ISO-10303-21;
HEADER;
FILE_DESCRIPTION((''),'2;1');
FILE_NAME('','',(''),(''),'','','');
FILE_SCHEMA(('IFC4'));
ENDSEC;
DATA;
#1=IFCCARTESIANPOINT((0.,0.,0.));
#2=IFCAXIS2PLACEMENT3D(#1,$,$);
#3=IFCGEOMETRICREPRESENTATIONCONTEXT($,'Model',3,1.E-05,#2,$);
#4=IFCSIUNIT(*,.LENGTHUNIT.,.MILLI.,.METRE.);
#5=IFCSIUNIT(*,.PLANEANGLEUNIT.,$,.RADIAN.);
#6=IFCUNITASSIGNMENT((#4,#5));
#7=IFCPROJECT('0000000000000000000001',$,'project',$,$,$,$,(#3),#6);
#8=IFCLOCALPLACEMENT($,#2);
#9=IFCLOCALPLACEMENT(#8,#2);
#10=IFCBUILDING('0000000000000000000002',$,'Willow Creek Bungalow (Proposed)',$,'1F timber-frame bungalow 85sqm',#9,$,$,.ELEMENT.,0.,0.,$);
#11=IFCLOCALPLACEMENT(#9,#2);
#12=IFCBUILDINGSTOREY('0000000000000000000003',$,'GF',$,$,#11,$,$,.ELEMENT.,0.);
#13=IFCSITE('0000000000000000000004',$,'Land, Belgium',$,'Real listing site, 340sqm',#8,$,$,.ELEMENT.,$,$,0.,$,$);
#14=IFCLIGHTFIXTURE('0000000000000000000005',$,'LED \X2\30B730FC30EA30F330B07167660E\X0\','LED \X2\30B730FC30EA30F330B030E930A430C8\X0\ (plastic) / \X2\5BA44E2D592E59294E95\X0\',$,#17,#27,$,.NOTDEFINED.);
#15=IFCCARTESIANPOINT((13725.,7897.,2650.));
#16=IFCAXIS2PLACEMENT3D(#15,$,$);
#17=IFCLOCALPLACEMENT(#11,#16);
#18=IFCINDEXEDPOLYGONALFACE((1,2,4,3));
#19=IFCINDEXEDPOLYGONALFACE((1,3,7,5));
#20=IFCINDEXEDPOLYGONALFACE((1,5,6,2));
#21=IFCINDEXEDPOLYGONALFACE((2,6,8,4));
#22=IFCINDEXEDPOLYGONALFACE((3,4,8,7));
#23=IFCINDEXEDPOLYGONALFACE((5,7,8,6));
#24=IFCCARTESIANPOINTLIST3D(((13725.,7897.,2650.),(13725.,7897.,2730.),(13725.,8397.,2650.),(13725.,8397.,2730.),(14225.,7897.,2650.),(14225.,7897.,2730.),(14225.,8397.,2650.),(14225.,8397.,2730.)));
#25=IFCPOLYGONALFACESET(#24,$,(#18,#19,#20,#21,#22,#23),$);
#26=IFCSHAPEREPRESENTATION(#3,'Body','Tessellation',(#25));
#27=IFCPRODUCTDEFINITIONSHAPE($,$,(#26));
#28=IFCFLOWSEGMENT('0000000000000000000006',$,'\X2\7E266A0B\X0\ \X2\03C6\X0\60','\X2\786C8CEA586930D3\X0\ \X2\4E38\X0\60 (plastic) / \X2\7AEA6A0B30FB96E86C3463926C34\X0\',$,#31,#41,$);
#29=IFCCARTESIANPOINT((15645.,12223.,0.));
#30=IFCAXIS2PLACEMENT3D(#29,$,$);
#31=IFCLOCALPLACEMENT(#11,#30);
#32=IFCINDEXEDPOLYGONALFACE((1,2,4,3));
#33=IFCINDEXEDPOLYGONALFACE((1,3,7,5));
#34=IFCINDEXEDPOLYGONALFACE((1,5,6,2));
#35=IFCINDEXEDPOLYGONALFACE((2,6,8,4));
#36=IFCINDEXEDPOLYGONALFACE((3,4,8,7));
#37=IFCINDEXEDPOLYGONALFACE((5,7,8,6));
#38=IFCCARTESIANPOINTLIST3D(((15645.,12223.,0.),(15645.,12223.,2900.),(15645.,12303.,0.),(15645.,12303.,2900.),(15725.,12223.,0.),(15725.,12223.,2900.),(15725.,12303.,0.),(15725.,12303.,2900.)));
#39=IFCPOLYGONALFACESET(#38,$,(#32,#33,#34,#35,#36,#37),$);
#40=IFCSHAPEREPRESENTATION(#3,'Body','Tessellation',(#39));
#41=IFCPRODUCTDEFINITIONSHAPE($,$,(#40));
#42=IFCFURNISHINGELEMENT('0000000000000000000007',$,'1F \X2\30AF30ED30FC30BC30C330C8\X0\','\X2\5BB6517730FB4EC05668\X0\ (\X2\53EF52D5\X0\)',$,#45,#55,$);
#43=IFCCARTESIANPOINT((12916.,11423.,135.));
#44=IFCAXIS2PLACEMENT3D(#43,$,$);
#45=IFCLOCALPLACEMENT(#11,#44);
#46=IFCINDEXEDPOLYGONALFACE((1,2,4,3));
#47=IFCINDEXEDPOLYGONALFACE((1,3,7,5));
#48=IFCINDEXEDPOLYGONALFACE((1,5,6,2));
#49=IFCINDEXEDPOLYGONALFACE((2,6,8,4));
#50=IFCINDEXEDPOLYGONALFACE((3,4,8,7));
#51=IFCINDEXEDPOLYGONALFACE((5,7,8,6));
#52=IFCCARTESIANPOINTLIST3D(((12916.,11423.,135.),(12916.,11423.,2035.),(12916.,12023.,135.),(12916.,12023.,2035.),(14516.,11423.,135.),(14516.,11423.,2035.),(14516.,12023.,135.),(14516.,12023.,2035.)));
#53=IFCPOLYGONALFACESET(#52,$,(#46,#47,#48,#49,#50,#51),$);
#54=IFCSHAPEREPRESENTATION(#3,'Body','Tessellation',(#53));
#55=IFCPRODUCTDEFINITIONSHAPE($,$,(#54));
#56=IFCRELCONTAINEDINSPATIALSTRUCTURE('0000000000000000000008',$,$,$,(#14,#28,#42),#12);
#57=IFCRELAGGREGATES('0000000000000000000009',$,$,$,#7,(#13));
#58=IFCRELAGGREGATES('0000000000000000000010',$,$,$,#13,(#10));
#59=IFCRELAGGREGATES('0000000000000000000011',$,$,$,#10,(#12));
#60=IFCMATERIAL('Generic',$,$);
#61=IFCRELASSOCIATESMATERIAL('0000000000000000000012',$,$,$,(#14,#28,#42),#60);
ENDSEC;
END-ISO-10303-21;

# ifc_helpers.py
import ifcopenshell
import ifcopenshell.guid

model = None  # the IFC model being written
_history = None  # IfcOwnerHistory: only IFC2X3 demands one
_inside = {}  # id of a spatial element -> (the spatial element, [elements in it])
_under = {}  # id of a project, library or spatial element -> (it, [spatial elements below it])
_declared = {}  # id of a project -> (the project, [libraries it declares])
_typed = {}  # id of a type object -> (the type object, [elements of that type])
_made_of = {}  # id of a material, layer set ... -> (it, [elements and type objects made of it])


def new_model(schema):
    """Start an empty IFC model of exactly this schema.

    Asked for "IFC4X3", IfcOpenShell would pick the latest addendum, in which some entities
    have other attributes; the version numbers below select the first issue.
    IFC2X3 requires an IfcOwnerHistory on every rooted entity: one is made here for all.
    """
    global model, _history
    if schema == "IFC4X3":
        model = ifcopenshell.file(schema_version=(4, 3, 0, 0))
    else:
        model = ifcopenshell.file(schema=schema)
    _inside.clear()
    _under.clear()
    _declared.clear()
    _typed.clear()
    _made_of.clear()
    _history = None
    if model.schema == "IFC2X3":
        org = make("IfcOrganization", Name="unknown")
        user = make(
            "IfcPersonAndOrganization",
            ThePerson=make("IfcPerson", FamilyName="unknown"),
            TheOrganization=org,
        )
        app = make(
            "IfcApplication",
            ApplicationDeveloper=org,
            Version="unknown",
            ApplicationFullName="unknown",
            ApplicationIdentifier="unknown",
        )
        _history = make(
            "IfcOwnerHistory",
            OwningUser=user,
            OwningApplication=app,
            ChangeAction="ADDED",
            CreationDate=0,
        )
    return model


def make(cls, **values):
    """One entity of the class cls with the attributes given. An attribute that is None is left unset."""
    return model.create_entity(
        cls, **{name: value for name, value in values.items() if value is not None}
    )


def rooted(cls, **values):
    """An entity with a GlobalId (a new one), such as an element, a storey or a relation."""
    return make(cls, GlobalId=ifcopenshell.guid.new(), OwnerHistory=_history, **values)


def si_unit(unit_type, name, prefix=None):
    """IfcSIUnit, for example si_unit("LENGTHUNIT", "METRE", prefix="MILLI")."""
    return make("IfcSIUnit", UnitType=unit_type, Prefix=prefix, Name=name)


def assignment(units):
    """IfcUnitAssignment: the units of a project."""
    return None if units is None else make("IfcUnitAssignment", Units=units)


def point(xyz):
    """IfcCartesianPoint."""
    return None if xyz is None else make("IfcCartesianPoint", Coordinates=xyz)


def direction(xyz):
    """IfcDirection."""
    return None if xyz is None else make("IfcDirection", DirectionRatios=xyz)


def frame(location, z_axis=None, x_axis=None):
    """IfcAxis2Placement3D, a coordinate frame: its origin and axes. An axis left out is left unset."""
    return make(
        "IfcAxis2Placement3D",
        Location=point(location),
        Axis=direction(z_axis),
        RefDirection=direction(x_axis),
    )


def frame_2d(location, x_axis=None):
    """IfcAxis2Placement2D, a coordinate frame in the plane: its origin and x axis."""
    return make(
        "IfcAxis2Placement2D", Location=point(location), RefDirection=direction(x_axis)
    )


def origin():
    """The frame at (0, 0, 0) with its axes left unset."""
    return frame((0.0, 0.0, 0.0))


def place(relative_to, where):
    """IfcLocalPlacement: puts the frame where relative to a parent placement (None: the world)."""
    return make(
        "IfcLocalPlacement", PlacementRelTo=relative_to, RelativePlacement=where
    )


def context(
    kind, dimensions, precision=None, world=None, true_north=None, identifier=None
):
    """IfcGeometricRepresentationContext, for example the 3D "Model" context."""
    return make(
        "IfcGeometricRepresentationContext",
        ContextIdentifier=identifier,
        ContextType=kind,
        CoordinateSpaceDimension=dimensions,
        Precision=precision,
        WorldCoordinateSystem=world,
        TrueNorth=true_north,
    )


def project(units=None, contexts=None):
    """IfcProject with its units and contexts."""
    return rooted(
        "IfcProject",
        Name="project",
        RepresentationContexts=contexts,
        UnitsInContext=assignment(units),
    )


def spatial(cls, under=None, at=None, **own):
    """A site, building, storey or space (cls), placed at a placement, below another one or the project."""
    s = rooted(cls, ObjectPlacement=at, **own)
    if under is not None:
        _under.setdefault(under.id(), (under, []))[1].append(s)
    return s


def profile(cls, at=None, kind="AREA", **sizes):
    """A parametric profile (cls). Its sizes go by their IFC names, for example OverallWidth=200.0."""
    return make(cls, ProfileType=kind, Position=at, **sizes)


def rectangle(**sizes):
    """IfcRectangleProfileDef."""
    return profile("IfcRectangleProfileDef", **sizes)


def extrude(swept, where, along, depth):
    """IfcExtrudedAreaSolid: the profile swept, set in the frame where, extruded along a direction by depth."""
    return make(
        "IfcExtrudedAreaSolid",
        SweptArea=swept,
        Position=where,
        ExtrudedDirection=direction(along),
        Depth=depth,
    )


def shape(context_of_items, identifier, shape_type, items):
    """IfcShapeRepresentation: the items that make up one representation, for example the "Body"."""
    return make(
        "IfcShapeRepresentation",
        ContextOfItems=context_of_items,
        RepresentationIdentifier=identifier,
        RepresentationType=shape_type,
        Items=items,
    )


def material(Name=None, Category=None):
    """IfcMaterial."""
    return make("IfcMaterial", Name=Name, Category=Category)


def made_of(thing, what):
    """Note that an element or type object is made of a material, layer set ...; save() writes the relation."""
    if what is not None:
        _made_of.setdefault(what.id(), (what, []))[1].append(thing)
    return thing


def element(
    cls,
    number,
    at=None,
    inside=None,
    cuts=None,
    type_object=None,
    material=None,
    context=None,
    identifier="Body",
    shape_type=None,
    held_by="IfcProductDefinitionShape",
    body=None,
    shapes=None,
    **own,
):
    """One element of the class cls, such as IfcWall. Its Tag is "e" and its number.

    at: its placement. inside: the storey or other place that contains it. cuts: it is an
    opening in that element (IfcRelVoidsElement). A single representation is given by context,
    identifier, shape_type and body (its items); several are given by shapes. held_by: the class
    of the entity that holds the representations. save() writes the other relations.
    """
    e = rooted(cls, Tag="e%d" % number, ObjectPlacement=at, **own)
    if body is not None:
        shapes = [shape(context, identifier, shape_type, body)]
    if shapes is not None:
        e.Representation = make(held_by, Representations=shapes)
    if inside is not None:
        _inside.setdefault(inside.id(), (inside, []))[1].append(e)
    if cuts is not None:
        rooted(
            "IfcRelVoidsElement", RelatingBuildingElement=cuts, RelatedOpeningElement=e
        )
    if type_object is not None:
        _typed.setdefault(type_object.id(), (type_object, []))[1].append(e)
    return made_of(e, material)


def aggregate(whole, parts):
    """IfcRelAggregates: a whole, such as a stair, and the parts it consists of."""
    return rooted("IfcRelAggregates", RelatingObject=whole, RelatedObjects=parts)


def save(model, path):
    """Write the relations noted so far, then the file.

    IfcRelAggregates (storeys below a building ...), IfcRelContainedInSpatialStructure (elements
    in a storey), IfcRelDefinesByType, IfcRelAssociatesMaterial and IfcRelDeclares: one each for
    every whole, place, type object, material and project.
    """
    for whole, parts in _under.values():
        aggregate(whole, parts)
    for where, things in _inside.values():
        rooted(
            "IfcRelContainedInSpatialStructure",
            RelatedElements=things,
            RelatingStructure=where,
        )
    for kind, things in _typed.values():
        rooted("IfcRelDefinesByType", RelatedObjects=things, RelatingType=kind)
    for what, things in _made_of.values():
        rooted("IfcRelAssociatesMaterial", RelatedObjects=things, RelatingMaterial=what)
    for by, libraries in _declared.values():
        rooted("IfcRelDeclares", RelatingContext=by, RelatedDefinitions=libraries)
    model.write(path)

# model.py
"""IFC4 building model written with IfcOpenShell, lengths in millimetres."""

from ifc_helpers import new_model, si_unit, frame, frame_2d, origin, place, context, project, spatial, rectangle, extrude, material, element, save


model = new_model("IFC4")

# Units and contexts
model_context = context("Model", 3, precision=1e-05, world=origin())
ifc_project = project(units=[si_unit("LENGTHUNIT", "METRE", prefix="MILLI"), si_unit("PLANEANGLEUNIT", "RADIAN")], contexts=[model_context])

# Site, building, storey
site_placement = place(None, origin())
site = spatial("IfcSite", under=ifc_project, at=site_placement, Name="Land, Belgium", ObjectType="Real listing site, 340sqm", CompositionType="ELEMENT", RefElevation=0.0)
building_placement = place(site_placement, origin())
building = spatial("IfcBuilding", under=site, at=building_placement, Name="Willow Creek Bungalow (Proposed)", ObjectType="1F timber-frame bungalow 85sqm", CompositionType="ELEMENT", ElevationOfRefHeight=0.0, ElevationOfTerrain=0.0)
storey_placement = place(building_placement, origin())
storey = spatial("IfcBuildingStorey", under=building, at=storey_placement, Name="GF", CompositionType="ELEMENT", Elevation=0.0)

# Shared definitions
ifc_material_1 = material(Name="Generic")

# Light fixture
light_fixture_1_placement = place(storey_placement, frame((13725.0, 7897.0, 2650.0)))
element("IfcLightFixture", 1, at=light_fixture_1_placement, inside=storey, material=ifc_material_1, Name="LED シーリング照明", Description="LED シーリングライト (plastic) / 室中央天井", PredefinedType="NOTDEFINED", context=model_context, shape_type="SweptSolid", body=[
    extrude(rectangle(XDim=500.0, YDim=500.0, at=frame_2d((250.0, 250.0))), frame((13725.0, 7897.0, 2650.0)), (0.0, 0.0, 1.0), 80.0),
])

# Flow segment
flow_segment_placement = place(storey_placement, frame((15645.0, 12223.0, 0.0)))
element("IfcFlowSegment", 2, at=flow_segment_placement, inside=storey, material=ifc_material_1, Name="縦樋 φ60", Description="硬質塩ビ 丸60 (plastic) / 竪樋・雨水排水", context=model_context, shape_type="SweptSolid", body=[
    extrude(rectangle(XDim=80.0, YDim=80.0, at=frame_2d((40.0, 40.0))), frame((15645.0, 12223.0, 0.0)), (0.0, 0.0, 1.0), 2900.0),
])

# Furnishing element
furnishing_placement = place(storey_placement, frame((12916.0, 11423.0, 135.0)))
element("IfcFurnishingElement", 3, at=furnishing_placement, inside=storey, material=ifc_material_1, Name="1F クローゼット", Description="家具・什器 (可動)", context=model_context, shape_type="SweptSolid", body=[
    extrude(rectangle(XDim=1600.0, YDim=600.0, at=frame_2d((800.0, 300.0))), frame((12916.0, 11423.0, 135.0)), (0.0, 0.0, 1.0), 1900.0),
])

save(model, "model.ifc")
